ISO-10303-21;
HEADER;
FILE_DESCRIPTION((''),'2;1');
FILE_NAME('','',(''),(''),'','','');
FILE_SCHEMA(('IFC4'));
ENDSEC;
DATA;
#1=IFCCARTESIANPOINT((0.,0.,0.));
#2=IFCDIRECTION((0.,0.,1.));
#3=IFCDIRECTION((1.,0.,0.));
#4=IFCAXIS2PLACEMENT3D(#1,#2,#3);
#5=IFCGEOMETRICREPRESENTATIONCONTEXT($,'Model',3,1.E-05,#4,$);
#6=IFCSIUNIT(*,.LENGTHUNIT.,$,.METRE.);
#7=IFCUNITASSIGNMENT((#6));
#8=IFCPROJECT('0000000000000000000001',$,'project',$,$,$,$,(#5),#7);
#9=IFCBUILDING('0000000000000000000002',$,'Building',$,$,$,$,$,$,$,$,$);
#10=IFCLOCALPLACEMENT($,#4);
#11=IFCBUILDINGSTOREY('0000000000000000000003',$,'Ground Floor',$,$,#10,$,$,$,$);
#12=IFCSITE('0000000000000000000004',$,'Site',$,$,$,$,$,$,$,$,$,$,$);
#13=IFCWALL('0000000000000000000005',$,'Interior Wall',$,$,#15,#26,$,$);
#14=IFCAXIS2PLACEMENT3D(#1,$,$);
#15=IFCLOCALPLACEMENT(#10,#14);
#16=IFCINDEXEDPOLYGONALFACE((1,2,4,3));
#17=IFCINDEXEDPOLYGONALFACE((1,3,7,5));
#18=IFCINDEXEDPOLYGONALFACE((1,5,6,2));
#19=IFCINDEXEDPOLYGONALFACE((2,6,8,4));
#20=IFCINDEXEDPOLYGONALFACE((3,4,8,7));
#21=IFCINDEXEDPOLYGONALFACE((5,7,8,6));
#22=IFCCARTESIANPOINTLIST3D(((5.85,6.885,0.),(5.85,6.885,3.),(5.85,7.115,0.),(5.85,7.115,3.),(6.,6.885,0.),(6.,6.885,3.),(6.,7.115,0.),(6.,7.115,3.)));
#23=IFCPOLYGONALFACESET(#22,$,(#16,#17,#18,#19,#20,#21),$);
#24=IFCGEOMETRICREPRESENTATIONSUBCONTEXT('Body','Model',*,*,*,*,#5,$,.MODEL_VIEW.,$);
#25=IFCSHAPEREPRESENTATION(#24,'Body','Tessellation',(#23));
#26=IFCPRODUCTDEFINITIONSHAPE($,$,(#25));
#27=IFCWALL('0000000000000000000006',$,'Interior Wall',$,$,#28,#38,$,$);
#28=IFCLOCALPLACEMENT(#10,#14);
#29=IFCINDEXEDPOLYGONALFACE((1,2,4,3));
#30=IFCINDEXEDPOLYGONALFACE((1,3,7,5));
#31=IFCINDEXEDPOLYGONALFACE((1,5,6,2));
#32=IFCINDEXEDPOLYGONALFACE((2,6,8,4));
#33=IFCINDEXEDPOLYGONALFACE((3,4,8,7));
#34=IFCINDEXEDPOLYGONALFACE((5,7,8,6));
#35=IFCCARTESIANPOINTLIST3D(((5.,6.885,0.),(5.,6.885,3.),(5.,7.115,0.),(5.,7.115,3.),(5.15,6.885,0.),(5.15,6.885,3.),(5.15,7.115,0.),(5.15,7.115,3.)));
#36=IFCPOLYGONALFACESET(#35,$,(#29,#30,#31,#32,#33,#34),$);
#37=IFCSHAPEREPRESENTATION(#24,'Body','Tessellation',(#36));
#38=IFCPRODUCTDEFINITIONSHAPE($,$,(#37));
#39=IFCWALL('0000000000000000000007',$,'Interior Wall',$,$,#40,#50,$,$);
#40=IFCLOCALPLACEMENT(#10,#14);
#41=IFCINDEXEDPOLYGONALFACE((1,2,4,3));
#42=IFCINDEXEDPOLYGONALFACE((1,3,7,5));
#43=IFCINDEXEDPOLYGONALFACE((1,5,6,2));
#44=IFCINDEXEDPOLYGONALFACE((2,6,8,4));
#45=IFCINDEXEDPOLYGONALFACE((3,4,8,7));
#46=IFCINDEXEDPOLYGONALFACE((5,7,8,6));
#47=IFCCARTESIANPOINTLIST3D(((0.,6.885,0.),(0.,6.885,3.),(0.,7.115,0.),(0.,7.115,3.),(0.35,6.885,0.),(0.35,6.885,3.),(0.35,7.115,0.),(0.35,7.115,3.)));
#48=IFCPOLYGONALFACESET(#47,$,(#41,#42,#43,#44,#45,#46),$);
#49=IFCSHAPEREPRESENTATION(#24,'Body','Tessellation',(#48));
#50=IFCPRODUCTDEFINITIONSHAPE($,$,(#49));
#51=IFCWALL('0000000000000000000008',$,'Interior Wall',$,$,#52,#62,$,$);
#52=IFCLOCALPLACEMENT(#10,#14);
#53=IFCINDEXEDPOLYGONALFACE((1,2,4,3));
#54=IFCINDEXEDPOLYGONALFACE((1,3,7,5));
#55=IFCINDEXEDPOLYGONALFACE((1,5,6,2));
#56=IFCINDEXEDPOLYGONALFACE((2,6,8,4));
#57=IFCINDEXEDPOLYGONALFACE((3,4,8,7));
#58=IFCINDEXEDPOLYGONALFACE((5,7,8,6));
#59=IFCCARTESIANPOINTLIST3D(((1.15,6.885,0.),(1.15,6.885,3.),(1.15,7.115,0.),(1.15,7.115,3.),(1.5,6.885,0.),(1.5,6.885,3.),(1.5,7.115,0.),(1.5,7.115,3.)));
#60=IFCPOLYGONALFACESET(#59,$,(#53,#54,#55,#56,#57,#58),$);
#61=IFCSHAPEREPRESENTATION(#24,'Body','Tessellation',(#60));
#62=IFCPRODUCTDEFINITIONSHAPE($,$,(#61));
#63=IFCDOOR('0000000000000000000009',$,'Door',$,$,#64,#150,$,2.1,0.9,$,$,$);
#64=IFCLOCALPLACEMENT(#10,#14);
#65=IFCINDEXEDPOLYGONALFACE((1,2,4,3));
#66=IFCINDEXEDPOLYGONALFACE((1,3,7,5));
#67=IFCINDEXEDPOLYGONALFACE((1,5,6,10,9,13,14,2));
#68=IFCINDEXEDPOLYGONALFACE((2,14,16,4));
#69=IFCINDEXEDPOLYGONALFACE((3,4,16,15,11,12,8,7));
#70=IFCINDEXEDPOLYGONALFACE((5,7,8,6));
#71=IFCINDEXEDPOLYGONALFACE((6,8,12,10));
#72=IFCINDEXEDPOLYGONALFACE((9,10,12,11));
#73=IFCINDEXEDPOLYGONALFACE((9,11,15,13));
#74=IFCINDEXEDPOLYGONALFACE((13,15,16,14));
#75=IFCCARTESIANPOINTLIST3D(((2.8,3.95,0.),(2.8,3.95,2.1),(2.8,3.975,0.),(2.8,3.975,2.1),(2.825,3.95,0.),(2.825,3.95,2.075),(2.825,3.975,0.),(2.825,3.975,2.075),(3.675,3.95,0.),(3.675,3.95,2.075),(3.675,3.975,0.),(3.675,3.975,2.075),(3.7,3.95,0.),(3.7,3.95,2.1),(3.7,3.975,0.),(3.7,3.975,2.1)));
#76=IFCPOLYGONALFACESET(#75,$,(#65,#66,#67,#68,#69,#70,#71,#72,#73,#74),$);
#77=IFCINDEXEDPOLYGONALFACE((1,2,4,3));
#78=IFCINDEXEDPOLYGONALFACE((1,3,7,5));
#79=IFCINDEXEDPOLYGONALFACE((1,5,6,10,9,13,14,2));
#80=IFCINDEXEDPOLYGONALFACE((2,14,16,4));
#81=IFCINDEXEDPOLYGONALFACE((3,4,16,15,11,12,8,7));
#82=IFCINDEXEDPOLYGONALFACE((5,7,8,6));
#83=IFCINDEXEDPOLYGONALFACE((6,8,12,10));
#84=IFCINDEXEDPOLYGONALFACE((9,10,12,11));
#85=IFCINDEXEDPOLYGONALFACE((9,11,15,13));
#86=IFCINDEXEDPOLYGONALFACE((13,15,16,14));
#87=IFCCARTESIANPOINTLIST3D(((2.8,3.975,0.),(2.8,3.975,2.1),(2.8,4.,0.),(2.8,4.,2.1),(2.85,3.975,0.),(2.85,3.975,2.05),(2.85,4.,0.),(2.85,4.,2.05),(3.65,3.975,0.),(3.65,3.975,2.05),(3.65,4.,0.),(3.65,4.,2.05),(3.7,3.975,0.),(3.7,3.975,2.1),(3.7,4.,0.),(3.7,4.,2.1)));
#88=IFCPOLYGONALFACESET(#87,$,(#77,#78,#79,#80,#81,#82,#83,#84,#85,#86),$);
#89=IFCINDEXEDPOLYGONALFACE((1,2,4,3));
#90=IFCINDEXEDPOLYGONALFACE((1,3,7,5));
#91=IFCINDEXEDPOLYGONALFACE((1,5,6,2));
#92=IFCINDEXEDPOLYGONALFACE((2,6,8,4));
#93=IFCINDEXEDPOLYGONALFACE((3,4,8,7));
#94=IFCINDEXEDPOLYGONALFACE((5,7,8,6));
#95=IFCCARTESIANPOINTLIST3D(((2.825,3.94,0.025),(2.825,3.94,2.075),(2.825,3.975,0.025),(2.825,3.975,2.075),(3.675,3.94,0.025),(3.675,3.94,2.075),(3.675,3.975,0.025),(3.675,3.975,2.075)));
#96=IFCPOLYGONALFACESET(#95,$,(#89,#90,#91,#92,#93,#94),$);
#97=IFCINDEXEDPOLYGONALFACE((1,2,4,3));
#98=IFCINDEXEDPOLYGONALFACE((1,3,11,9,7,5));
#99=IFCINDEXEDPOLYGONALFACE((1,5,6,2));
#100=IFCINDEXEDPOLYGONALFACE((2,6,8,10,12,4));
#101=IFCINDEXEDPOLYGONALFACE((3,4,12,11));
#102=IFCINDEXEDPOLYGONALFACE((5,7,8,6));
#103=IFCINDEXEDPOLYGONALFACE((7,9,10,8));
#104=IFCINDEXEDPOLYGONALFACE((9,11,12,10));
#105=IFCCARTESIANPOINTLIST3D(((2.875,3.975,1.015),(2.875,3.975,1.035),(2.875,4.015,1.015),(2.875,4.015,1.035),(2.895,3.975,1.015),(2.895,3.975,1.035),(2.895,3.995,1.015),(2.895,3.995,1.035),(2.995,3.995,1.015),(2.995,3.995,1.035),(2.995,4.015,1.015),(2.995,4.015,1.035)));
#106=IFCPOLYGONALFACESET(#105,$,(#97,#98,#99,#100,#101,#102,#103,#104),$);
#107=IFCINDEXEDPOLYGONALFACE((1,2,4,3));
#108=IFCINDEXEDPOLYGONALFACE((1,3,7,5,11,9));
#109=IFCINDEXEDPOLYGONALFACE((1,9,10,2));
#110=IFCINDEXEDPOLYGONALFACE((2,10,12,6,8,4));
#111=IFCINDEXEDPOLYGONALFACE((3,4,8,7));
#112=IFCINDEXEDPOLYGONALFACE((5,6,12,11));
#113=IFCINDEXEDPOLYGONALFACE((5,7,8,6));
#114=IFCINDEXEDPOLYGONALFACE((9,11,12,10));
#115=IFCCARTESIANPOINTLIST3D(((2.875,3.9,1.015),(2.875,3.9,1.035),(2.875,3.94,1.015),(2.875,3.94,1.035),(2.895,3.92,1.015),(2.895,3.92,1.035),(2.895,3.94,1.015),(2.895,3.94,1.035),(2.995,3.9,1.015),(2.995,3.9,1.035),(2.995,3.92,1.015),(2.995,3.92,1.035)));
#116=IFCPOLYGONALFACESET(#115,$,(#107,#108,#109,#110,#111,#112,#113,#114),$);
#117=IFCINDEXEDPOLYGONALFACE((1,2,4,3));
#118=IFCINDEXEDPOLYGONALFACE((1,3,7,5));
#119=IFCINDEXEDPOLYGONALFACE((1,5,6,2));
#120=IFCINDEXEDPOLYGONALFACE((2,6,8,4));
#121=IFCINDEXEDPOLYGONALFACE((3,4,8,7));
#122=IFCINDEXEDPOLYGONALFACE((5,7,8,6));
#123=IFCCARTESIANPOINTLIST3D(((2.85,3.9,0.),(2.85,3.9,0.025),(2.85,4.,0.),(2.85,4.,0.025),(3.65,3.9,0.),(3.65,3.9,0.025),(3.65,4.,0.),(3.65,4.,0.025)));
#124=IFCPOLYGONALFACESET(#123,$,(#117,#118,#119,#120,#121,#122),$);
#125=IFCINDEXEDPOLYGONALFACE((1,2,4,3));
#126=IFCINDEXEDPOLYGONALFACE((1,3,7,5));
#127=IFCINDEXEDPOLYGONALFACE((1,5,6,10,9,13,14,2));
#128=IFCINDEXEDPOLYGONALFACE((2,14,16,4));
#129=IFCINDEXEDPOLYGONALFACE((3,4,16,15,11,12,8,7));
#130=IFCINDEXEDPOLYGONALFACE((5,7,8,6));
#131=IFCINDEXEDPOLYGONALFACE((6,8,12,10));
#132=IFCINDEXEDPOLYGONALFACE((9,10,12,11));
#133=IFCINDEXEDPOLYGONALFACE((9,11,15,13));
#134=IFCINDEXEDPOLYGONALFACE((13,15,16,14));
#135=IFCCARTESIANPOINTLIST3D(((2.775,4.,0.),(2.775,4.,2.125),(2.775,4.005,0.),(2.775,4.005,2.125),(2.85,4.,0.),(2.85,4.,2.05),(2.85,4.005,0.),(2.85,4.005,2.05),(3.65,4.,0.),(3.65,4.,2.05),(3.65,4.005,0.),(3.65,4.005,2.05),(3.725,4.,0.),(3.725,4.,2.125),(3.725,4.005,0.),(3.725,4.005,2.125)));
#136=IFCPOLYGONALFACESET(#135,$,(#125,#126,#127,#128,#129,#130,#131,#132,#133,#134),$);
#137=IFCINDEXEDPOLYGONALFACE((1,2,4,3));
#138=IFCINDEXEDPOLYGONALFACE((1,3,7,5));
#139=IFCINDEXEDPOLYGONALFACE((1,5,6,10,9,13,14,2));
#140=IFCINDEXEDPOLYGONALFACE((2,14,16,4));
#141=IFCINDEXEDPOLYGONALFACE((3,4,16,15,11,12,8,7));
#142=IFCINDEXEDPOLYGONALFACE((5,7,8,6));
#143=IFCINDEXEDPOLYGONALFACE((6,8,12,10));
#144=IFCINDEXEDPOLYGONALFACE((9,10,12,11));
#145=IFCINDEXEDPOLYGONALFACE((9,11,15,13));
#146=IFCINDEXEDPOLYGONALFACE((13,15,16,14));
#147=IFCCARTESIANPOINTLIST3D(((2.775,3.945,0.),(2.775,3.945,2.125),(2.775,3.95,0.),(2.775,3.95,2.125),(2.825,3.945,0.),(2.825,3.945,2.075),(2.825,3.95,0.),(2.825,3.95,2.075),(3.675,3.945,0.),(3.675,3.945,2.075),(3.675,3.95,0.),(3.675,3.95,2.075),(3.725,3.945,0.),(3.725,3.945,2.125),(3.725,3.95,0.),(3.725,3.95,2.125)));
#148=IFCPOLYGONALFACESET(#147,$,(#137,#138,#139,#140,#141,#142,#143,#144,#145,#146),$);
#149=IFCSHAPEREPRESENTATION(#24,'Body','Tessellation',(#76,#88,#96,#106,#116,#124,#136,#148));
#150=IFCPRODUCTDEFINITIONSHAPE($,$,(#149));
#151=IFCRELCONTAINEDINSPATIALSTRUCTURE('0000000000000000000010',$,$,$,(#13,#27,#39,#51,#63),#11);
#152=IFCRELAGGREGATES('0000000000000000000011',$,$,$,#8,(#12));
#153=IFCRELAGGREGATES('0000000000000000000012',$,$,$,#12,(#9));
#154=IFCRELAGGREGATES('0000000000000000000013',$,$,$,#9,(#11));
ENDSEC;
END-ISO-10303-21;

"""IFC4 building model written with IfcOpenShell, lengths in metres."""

from ifc_helpers import new_model, si_unit, frame, origin_with_axes, place, context, subcontext, project, spatial, line, indexed_curve, outline, extrude, element, save


model = new_model("IFC4")

# Units and contexts
model_context = context("Model", 3, precision=1e-05, world=origin_with_axes())
body_context = subcontext(model_context, "Body", "Model", "MODEL_VIEW")
ifc_project = project(units=[si_unit("LENGTHUNIT", "METRE")], contexts=[model_context])

# Site, building, storey
site = spatial("IfcSite", under=ifc_project, Name="Site")
building = spatial("IfcBuilding", under=site, Name="Building")
storey_placement = place(None, origin_with_axes())
storey = spatial("IfcBuildingStorey", under=building, at=storey_placement, Name="Ground Floor")

# Walls
for number, where, z_axis, x_axis, name in (
    (1, (6.0, 7.0, 0.0), (0.0, 0.0, 1.0), (-1.0, 0.0, 0.0), "Interior Wall"),
    (2, (5.15, 7.0, 0.0), (0.0, 0.0, 1.0), (-1.0, 0.0, 0.0), "Interior Wall"),
):
    element("IfcWall", number, at=place(storey_placement, frame(where, z_axis=z_axis, x_axis=x_axis)), inside=storey, Name=name, context=body_context, shape_type="SweptSolid", body=[
        extrude(outline(indexed_curve([(0.0, 0.0), (0.0, 0.23), (0.15, 0.23), (0.15, 0.0), (0.0, 0.0)], self_intersect=False)), frame((0.0, -0.115, 0.0), z_axis=(0.0, 0.0, 1.0), x_axis=(1.0, 0.0, 0.0)), (0.0, 0.0, 1.0), 3.0),
    ])
wall_1_placement = place(storey_placement, frame((0.0, 7.0, 0.0), z_axis=(0.0, 0.0, 1.0), x_axis=(1.0, 0.0, 0.0)))
element("IfcWall", 3, at=wall_1_placement, inside=storey, Name="Interior Wall", context=body_context, shape_type="SweptSolid", body=[
    extrude(outline(indexed_curve([(0.0, 0.0), (0.0, 0.23), (0.35, 0.23), (0.35, 0.0), (0.0, 0.0)], self_intersect=False)), frame((0.0, -0.115, 0.0), z_axis=(0.0, 0.0, 1.0), x_axis=(1.0, 0.0, 0.0)), (0.0, 0.0, 1.0), 3.0),
])
wall_2_placement = place(storey_placement, frame((1.15, 7.0, 0.0), z_axis=(0.0, 0.0, 1.0), x_axis=(1.0, 0.0, 0.0)))
element("IfcWall", 4, at=wall_2_placement, inside=storey, Name="Interior Wall", context=body_context, shape_type="SweptSolid", body=[
    extrude(outline(indexed_curve([(0.0, 0.0), (0.0, 0.23), (0.35, 0.23), (0.35, 0.0), (0.0, 0.0)], self_intersect=False)), frame((0.0, -0.115, 0.0), z_axis=(0.0, 0.0, 1.0), x_axis=(1.0, 0.0, 0.0)), (0.0, 0.0, 1.0), 3.0),
])

# Door
door_1_placement = place(storey_placement, frame((3.7, 4.0, 0.0), z_axis=(0.0, 0.0, 1.0), x_axis=(-1.0, 0.0, 0.0)))
element("IfcDoor", 5, at=door_1_placement, inside=storey, Name="Door", OverallHeight=2.1, OverallWidth=0.9, context=body_context, shape_type="SweptSolid", body=[
    extrude(outline(indexed_curve([(0.0, 0.0), (0.0, 2.1), (0.9, 2.1), (0.9, 0.0), (0.875, 0.0), (0.875, 2.075), (0.025, 2.075), (0.025, 0.0)], segments=[line(1, 2, 3, 4, 5, 6, 7, 8, 1)])), frame((0.0, 0.025, 0.0), z_axis=(0.0, -1.0, 0.0), x_axis=(1.0, 0.0, 0.0)), (0.0, 0.0, -1.0), 0.025),
    extrude(outline(indexed_curve([(0.0, 0.0), (0.0, 2.1), (0.9, 2.1), (0.9, 0.0), (0.85, 0.0), (0.85, 2.05), (0.05, 2.05), (0.05, 0.0)], segments=[line(1, 2, 3, 4, 5, 6, 7, 8, 1)])), frame((0.0, 0.0, 0.0), z_axis=(0.0, -1.0, 0.0), x_axis=(1.0, 0.0, 0.0)), (0.0, 0.0, -1.0), 0.025),
    extrude(outline(indexed_curve([(0.0, 0.0), (0.85, 0.0), (0.85, 0.035), (0.0, 0.035)], segments=[line(1, 2, 3, 4, 1)])), frame((0.025, 0.025, 0.025), z_axis=(0.0, 0.0, 1.0), x_axis=(1.0, 0.0, 0.0)), (0.0, 0.0, 1.0), 2.05),
    extrude(outline(indexed_curve([(0.0, 0.0), (0.0, -0.04), (-0.12, -0.04), (-0.12, -0.02), (-0.02, -0.02), (-0.02, 0.0)], segments=[line(1, 2, 3, 4, 5, 6, 1)])), frame((0.825, 0.025, 1.015), z_axis=(0.0, 0.0, 1.0), x_axis=(1.0, 0.0, 0.0)), (0.0, 0.0, 1.0), 0.02),
    extrude(outline(indexed_curve([(0.0, 0.0), (0.0, 0.04), (-0.12, 0.04), (-0.12, 0.02), (-0.02, 0.02), (-0.02, 0.0)], segments=[line(1, 2, 3, 4, 5, 6, 1)])), frame((0.825, 0.06, 1.015), z_axis=(0.0, 0.0, 1.0), x_axis=(1.0, 0.0, 0.0)), (0.0, 0.0, 1.0), 0.02),
    extrude(outline(indexed_curve([(0.0, 0.0), (0.8, 0.0), (0.8, 0.1), (0.0, 0.1)], segments=[line(1, 2, 3, 4, 1)])), frame((0.05, 0.0, 0.0), z_axis=(0.0, 0.0, 1.0), x_axis=(1.0, 0.0, 0.0)), (0.0, 0.0, 1.0), 0.025),
    extrude(outline(indexed_curve([(0.0, 0.0), (0.0, 2.125), (0.95, 2.125), (0.95, 0.0), (0.875, 0.0), (0.875, 2.05), (0.075, 2.05), (0.075, 0.0)], segments=[line(1, 2, 3, 4, 5, 6, 7, 8, 1)])), frame((-0.025, -0.005, 0.0), z_axis=(0.0, -1.0, 0.0), x_axis=(1.0, 0.0, 0.0)), (0.0, 0.0, -1.0), 0.005),
    extrude(outline(indexed_curve([(0.0, 0.0), (0.0, 2.125), (0.95, 2.125), (0.95, 0.0), (0.9, 0.0), (0.9, 2.075), (0.05, 2.075), (0.05, 0.0)], segments=[line(1, 2, 3, 4, 5, 6, 7, 8, 1)])), frame((-0.025, 0.05, 0.0), z_axis=(0.0, -1.0, 0.0), x_axis=(1.0, 0.0, 0.0)), (0.0, 0.0, -1.0), 0.005),
])

save(model, "model.ifc")
